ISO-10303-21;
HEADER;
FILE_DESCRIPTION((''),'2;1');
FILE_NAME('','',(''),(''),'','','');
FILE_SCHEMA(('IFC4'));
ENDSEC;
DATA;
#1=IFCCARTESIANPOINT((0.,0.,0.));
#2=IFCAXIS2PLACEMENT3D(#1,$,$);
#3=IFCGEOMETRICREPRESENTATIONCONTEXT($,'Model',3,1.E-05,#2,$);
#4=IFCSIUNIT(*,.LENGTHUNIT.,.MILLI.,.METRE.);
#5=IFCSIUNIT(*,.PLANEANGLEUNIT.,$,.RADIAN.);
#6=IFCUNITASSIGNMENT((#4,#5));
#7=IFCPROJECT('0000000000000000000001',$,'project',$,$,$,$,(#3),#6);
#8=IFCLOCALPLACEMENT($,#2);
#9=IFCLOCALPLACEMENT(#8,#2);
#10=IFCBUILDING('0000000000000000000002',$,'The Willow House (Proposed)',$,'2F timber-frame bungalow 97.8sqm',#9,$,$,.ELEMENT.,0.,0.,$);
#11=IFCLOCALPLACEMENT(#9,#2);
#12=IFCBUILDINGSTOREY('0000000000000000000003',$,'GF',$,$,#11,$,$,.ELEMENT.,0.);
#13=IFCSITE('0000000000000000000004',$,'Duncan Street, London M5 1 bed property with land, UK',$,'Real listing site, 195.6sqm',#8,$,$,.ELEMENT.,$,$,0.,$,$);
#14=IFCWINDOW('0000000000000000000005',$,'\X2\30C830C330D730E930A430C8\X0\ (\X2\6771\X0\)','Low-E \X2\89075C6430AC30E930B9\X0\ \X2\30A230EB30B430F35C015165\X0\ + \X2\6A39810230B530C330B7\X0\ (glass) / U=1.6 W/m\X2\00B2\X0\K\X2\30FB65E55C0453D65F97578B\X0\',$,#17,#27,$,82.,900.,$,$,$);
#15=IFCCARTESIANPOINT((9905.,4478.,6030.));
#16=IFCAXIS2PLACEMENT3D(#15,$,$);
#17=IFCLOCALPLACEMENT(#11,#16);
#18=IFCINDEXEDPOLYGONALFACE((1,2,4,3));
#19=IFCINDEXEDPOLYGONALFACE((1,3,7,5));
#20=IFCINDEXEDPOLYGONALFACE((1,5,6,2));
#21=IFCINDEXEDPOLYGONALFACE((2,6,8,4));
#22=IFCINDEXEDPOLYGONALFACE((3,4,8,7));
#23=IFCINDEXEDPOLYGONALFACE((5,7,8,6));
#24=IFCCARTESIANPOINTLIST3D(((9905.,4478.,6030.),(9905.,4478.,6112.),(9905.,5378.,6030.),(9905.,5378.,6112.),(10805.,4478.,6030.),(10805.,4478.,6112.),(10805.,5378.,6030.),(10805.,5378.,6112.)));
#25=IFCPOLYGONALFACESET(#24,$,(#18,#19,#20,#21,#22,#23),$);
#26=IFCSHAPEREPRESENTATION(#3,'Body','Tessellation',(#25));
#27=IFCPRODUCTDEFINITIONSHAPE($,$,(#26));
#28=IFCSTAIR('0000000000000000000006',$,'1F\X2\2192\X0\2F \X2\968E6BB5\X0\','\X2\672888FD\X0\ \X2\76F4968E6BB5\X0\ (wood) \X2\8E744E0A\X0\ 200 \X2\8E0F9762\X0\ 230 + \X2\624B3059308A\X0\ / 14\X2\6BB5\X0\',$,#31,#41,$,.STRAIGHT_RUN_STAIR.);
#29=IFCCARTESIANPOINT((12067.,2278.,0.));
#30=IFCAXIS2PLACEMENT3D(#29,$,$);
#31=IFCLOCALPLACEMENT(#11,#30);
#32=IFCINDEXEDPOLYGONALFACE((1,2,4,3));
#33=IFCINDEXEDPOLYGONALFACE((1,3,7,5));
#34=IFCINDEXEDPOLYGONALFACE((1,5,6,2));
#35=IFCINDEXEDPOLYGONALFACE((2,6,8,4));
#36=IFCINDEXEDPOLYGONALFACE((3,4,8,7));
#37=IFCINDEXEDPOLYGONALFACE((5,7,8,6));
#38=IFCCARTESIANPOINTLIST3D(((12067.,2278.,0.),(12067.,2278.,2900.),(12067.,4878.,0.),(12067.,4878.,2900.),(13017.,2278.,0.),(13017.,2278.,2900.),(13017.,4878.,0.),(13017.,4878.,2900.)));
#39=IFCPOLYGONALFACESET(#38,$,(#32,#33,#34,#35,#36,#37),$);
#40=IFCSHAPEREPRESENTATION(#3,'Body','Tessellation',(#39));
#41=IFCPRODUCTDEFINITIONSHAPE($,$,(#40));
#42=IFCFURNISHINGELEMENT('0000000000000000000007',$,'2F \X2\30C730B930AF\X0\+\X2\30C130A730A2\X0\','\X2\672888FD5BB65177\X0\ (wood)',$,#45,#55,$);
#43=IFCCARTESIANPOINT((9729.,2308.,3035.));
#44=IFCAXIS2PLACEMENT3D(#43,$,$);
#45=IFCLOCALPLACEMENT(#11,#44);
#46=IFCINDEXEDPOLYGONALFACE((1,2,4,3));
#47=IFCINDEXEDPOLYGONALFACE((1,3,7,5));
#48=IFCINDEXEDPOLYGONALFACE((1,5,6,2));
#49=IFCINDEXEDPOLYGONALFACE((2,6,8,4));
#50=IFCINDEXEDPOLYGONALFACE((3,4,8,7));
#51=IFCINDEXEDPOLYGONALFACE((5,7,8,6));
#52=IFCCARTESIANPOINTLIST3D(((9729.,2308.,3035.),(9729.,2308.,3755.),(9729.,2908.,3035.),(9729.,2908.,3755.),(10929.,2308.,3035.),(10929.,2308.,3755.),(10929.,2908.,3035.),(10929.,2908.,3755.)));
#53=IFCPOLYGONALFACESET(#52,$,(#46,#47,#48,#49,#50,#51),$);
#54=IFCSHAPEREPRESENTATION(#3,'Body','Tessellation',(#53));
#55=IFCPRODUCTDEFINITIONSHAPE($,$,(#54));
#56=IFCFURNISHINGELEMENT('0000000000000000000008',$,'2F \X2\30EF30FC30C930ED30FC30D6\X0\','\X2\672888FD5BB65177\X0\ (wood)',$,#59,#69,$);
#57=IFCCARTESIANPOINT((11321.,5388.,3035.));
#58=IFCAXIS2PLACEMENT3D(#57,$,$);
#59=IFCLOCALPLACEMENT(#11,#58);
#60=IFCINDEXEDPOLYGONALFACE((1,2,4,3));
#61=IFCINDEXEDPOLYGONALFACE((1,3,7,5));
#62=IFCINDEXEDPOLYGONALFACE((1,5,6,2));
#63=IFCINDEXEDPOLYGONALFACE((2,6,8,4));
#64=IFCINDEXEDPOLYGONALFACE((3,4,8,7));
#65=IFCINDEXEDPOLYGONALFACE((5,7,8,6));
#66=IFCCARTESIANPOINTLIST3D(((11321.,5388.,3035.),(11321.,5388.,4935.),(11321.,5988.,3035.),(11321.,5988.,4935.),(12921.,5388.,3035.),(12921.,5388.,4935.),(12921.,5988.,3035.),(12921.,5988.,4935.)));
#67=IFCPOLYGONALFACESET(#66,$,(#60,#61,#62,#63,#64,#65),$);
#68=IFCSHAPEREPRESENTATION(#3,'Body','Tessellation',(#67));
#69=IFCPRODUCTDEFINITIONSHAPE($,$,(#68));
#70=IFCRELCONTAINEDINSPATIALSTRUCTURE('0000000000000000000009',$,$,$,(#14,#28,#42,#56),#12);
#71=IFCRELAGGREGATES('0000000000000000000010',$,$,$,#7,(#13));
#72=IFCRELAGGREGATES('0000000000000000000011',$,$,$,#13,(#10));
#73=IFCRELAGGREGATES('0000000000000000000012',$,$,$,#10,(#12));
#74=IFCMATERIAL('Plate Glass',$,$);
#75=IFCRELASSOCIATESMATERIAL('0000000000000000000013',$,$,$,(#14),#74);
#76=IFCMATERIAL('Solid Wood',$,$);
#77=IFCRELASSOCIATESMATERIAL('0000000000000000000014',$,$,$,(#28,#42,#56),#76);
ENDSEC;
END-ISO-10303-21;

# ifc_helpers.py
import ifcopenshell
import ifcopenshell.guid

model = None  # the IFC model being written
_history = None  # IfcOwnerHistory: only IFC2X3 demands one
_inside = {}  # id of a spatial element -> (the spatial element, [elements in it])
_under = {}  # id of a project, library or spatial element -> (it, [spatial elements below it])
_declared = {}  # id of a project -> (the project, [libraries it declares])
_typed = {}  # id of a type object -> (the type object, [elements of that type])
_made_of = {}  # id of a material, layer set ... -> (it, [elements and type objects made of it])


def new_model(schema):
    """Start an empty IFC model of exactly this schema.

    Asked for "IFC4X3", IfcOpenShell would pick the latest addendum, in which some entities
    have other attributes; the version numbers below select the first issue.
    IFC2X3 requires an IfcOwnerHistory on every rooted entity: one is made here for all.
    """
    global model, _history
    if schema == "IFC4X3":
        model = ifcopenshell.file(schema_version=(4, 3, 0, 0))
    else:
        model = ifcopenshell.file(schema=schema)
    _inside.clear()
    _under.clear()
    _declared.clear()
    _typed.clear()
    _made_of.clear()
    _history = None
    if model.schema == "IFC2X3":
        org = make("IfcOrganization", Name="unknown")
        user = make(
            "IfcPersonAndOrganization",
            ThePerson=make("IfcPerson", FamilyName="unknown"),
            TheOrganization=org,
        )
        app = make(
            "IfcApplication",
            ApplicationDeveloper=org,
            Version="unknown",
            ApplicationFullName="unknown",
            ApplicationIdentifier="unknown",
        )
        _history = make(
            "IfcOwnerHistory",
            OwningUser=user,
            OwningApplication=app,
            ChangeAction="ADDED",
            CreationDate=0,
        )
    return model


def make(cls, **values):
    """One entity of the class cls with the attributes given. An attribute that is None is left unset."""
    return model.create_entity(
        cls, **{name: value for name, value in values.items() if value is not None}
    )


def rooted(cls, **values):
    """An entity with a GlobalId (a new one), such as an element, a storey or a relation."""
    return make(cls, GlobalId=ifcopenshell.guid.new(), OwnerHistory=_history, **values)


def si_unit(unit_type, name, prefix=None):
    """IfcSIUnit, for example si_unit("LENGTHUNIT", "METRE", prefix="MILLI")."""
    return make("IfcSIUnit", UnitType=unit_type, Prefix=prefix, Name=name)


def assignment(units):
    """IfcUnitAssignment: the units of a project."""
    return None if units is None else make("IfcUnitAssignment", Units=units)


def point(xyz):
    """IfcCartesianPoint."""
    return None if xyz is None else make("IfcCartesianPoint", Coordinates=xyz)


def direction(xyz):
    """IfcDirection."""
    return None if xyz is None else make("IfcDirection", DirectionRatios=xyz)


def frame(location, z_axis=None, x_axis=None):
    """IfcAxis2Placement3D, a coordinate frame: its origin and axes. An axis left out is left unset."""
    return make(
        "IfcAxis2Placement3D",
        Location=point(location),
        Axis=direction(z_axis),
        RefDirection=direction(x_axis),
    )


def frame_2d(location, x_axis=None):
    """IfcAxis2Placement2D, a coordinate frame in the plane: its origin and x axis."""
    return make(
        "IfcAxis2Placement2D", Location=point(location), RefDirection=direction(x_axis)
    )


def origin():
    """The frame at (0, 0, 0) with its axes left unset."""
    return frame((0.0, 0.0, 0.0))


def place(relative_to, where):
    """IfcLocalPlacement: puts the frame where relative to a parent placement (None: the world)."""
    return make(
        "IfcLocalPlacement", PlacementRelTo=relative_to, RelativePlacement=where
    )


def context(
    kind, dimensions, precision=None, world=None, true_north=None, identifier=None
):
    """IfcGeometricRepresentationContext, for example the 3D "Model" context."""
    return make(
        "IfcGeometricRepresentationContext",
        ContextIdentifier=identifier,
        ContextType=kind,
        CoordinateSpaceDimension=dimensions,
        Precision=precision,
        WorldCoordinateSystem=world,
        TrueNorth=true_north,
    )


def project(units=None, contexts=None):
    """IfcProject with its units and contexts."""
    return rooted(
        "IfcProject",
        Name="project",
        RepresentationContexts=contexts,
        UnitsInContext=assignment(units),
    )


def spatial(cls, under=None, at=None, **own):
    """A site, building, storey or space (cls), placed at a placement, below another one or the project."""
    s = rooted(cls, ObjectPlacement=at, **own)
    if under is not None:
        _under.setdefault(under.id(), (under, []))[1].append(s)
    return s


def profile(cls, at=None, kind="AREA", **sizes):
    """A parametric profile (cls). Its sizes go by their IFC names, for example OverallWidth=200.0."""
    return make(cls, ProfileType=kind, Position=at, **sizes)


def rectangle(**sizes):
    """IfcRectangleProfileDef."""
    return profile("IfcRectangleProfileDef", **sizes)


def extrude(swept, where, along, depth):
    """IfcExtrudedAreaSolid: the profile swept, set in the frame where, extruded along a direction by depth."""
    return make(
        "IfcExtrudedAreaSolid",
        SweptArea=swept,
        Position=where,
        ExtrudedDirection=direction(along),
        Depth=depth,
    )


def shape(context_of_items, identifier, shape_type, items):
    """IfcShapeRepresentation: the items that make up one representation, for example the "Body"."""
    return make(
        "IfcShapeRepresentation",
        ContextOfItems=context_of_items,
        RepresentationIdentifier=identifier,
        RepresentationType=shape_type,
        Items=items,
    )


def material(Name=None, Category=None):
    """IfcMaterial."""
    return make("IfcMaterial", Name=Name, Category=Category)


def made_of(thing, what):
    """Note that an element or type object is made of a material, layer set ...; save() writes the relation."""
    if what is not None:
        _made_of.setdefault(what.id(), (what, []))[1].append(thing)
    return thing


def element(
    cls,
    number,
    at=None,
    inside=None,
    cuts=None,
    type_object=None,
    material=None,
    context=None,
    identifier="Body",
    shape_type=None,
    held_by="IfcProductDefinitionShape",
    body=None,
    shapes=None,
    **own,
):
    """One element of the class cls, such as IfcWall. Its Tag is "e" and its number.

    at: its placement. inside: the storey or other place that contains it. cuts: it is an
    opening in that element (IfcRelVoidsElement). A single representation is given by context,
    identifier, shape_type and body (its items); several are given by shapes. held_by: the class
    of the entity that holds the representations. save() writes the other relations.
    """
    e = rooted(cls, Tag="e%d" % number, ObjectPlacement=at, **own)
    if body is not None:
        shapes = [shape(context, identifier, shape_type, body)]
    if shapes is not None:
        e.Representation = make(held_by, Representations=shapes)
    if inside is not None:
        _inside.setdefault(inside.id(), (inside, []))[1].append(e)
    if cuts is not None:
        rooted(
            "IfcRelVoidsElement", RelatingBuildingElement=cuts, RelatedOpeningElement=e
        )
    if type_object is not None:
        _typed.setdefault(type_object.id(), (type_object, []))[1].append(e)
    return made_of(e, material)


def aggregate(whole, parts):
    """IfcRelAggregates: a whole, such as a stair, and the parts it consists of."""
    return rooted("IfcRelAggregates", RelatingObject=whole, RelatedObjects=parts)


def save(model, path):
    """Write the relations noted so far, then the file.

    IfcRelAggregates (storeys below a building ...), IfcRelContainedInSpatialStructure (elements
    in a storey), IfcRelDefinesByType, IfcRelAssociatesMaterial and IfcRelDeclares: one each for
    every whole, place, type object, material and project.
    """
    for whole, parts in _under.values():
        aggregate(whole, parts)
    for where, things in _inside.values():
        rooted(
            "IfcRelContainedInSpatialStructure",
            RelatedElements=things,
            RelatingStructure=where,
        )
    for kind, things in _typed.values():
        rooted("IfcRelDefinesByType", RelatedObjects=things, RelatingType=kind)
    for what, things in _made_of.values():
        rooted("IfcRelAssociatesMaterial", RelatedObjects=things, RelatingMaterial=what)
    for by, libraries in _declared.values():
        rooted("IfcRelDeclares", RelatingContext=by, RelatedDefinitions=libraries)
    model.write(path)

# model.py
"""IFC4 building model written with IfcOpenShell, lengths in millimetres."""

from ifc_helpers import new_model, si_unit, frame, frame_2d, origin, place, context, project, spatial, rectangle, extrude, material, element, save


model = new_model("IFC4")

# Units and contexts
model_context = context("Model", 3, precision=1e-05, world=origin())
ifc_project = project(units=[si_unit("LENGTHUNIT", "METRE", prefix="MILLI"), si_unit("PLANEANGLEUNIT", "RADIAN")], contexts=[model_context])

# Site, building, storey
site_placement = place(None, origin())
site = spatial("IfcSite", under=ifc_project, at=site_placement, Name="Duncan Street, London M5 1 bed property with land, UK", ObjectType="Real listing site, 195.6sqm", CompositionType="ELEMENT", RefElevation=0.0)
building_placement = place(site_placement, origin())
building = spatial("IfcBuilding", under=site, at=building_placement, Name="The Willow House (Proposed)", ObjectType="2F timber-frame bungalow 97.8sqm", CompositionType="ELEMENT", ElevationOfRefHeight=0.0, ElevationOfTerrain=0.0)
storey_placement = place(building_placement, origin())
storey = spatial("IfcBuildingStorey", under=building, at=storey_placement, Name="GF", CompositionType="ELEMENT", Elevation=0.0)

# Shared definitions
ifc_material_1 = material(Name="Solid Wood")

# Shared definitions
ifc_material_2 = material(Name="Plate Glass")

# Window
window_1_placement = place(storey_placement, frame((9905.0, 4478.0, 6030.0)))
element("IfcWindow", 1, at=window_1_placement, inside=storey, material=ifc_material_2, Name="トップライト (東)", Description="Low-E 複層ガラス アルゴン封入 + 樹脂サッシ (glass) / U=1.6 W/m²K・日射取得型", OverallHeight=82.0, OverallWidth=900.0, context=model_context, shape_type="SweptSolid", body=[
    extrude(rectangle(XDim=900.0, YDim=900.0, at=frame_2d((450.0, 450.0))), frame((9905.0, 4478.0, 6030.0)), (0.0, 0.0, 1.0), 82.0),
])

# Stair
stair_placement = place(storey_placement, frame((12067.0, 2278.0, 0.0)))
element("IfcStair", 2, at=stair_placement, inside=storey, material=ifc_material_1, Name="1F→2F 階段", Description="木製 直階段 (wood) 蹴上 200 踏面 230 + 手すり / 14段", PredefinedType="STRAIGHT_RUN_STAIR", context=model_context, shape_type="SweptSolid", body=[
    extrude(rectangle(XDim=950.0, YDim=2600.0, at=frame_2d((475.0, 1300.0))), frame((12067.0, 2278.0, 0.0)), (0.0, 0.0, 1.0), 2900.0),
])

# Furnishing elements
furnishing_1_placement = place(storey_placement, frame((9729.0, 2308.0, 3035.0)))
element("IfcFurnishingElement", 3, at=furnishing_1_placement, inside=storey, material=ifc_material_1, Name="2F デスク+チェア", Description="木製家具 (wood)", context=model_context, shape_type="SweptSolid", body=[
    extrude(rectangle(XDim=1200.0, YDim=600.0, at=frame_2d((600.0, 300.0))), frame((9729.0, 2308.0, 3035.0)), (0.0, 0.0, 1.0), 720.0),
])
furnishing_2_placement = place(storey_placement, frame((11321.0, 5388.0, 3035.0)))
element("IfcFurnishingElement", 4, at=furnishing_2_placement, inside=storey, material=ifc_material_1, Name="2F ワードローブ", Description="木製家具 (wood)", context=model_context, shape_type="SweptSolid", body=[
    extrude(rectangle(XDim=1600.0, YDim=600.0, at=frame_2d((800.0, 300.0))), frame((11321.0, 5388.0, 3035.0)), (0.0, 0.0, 1.0), 1900.0),
])

save(model, "model.ifc")
